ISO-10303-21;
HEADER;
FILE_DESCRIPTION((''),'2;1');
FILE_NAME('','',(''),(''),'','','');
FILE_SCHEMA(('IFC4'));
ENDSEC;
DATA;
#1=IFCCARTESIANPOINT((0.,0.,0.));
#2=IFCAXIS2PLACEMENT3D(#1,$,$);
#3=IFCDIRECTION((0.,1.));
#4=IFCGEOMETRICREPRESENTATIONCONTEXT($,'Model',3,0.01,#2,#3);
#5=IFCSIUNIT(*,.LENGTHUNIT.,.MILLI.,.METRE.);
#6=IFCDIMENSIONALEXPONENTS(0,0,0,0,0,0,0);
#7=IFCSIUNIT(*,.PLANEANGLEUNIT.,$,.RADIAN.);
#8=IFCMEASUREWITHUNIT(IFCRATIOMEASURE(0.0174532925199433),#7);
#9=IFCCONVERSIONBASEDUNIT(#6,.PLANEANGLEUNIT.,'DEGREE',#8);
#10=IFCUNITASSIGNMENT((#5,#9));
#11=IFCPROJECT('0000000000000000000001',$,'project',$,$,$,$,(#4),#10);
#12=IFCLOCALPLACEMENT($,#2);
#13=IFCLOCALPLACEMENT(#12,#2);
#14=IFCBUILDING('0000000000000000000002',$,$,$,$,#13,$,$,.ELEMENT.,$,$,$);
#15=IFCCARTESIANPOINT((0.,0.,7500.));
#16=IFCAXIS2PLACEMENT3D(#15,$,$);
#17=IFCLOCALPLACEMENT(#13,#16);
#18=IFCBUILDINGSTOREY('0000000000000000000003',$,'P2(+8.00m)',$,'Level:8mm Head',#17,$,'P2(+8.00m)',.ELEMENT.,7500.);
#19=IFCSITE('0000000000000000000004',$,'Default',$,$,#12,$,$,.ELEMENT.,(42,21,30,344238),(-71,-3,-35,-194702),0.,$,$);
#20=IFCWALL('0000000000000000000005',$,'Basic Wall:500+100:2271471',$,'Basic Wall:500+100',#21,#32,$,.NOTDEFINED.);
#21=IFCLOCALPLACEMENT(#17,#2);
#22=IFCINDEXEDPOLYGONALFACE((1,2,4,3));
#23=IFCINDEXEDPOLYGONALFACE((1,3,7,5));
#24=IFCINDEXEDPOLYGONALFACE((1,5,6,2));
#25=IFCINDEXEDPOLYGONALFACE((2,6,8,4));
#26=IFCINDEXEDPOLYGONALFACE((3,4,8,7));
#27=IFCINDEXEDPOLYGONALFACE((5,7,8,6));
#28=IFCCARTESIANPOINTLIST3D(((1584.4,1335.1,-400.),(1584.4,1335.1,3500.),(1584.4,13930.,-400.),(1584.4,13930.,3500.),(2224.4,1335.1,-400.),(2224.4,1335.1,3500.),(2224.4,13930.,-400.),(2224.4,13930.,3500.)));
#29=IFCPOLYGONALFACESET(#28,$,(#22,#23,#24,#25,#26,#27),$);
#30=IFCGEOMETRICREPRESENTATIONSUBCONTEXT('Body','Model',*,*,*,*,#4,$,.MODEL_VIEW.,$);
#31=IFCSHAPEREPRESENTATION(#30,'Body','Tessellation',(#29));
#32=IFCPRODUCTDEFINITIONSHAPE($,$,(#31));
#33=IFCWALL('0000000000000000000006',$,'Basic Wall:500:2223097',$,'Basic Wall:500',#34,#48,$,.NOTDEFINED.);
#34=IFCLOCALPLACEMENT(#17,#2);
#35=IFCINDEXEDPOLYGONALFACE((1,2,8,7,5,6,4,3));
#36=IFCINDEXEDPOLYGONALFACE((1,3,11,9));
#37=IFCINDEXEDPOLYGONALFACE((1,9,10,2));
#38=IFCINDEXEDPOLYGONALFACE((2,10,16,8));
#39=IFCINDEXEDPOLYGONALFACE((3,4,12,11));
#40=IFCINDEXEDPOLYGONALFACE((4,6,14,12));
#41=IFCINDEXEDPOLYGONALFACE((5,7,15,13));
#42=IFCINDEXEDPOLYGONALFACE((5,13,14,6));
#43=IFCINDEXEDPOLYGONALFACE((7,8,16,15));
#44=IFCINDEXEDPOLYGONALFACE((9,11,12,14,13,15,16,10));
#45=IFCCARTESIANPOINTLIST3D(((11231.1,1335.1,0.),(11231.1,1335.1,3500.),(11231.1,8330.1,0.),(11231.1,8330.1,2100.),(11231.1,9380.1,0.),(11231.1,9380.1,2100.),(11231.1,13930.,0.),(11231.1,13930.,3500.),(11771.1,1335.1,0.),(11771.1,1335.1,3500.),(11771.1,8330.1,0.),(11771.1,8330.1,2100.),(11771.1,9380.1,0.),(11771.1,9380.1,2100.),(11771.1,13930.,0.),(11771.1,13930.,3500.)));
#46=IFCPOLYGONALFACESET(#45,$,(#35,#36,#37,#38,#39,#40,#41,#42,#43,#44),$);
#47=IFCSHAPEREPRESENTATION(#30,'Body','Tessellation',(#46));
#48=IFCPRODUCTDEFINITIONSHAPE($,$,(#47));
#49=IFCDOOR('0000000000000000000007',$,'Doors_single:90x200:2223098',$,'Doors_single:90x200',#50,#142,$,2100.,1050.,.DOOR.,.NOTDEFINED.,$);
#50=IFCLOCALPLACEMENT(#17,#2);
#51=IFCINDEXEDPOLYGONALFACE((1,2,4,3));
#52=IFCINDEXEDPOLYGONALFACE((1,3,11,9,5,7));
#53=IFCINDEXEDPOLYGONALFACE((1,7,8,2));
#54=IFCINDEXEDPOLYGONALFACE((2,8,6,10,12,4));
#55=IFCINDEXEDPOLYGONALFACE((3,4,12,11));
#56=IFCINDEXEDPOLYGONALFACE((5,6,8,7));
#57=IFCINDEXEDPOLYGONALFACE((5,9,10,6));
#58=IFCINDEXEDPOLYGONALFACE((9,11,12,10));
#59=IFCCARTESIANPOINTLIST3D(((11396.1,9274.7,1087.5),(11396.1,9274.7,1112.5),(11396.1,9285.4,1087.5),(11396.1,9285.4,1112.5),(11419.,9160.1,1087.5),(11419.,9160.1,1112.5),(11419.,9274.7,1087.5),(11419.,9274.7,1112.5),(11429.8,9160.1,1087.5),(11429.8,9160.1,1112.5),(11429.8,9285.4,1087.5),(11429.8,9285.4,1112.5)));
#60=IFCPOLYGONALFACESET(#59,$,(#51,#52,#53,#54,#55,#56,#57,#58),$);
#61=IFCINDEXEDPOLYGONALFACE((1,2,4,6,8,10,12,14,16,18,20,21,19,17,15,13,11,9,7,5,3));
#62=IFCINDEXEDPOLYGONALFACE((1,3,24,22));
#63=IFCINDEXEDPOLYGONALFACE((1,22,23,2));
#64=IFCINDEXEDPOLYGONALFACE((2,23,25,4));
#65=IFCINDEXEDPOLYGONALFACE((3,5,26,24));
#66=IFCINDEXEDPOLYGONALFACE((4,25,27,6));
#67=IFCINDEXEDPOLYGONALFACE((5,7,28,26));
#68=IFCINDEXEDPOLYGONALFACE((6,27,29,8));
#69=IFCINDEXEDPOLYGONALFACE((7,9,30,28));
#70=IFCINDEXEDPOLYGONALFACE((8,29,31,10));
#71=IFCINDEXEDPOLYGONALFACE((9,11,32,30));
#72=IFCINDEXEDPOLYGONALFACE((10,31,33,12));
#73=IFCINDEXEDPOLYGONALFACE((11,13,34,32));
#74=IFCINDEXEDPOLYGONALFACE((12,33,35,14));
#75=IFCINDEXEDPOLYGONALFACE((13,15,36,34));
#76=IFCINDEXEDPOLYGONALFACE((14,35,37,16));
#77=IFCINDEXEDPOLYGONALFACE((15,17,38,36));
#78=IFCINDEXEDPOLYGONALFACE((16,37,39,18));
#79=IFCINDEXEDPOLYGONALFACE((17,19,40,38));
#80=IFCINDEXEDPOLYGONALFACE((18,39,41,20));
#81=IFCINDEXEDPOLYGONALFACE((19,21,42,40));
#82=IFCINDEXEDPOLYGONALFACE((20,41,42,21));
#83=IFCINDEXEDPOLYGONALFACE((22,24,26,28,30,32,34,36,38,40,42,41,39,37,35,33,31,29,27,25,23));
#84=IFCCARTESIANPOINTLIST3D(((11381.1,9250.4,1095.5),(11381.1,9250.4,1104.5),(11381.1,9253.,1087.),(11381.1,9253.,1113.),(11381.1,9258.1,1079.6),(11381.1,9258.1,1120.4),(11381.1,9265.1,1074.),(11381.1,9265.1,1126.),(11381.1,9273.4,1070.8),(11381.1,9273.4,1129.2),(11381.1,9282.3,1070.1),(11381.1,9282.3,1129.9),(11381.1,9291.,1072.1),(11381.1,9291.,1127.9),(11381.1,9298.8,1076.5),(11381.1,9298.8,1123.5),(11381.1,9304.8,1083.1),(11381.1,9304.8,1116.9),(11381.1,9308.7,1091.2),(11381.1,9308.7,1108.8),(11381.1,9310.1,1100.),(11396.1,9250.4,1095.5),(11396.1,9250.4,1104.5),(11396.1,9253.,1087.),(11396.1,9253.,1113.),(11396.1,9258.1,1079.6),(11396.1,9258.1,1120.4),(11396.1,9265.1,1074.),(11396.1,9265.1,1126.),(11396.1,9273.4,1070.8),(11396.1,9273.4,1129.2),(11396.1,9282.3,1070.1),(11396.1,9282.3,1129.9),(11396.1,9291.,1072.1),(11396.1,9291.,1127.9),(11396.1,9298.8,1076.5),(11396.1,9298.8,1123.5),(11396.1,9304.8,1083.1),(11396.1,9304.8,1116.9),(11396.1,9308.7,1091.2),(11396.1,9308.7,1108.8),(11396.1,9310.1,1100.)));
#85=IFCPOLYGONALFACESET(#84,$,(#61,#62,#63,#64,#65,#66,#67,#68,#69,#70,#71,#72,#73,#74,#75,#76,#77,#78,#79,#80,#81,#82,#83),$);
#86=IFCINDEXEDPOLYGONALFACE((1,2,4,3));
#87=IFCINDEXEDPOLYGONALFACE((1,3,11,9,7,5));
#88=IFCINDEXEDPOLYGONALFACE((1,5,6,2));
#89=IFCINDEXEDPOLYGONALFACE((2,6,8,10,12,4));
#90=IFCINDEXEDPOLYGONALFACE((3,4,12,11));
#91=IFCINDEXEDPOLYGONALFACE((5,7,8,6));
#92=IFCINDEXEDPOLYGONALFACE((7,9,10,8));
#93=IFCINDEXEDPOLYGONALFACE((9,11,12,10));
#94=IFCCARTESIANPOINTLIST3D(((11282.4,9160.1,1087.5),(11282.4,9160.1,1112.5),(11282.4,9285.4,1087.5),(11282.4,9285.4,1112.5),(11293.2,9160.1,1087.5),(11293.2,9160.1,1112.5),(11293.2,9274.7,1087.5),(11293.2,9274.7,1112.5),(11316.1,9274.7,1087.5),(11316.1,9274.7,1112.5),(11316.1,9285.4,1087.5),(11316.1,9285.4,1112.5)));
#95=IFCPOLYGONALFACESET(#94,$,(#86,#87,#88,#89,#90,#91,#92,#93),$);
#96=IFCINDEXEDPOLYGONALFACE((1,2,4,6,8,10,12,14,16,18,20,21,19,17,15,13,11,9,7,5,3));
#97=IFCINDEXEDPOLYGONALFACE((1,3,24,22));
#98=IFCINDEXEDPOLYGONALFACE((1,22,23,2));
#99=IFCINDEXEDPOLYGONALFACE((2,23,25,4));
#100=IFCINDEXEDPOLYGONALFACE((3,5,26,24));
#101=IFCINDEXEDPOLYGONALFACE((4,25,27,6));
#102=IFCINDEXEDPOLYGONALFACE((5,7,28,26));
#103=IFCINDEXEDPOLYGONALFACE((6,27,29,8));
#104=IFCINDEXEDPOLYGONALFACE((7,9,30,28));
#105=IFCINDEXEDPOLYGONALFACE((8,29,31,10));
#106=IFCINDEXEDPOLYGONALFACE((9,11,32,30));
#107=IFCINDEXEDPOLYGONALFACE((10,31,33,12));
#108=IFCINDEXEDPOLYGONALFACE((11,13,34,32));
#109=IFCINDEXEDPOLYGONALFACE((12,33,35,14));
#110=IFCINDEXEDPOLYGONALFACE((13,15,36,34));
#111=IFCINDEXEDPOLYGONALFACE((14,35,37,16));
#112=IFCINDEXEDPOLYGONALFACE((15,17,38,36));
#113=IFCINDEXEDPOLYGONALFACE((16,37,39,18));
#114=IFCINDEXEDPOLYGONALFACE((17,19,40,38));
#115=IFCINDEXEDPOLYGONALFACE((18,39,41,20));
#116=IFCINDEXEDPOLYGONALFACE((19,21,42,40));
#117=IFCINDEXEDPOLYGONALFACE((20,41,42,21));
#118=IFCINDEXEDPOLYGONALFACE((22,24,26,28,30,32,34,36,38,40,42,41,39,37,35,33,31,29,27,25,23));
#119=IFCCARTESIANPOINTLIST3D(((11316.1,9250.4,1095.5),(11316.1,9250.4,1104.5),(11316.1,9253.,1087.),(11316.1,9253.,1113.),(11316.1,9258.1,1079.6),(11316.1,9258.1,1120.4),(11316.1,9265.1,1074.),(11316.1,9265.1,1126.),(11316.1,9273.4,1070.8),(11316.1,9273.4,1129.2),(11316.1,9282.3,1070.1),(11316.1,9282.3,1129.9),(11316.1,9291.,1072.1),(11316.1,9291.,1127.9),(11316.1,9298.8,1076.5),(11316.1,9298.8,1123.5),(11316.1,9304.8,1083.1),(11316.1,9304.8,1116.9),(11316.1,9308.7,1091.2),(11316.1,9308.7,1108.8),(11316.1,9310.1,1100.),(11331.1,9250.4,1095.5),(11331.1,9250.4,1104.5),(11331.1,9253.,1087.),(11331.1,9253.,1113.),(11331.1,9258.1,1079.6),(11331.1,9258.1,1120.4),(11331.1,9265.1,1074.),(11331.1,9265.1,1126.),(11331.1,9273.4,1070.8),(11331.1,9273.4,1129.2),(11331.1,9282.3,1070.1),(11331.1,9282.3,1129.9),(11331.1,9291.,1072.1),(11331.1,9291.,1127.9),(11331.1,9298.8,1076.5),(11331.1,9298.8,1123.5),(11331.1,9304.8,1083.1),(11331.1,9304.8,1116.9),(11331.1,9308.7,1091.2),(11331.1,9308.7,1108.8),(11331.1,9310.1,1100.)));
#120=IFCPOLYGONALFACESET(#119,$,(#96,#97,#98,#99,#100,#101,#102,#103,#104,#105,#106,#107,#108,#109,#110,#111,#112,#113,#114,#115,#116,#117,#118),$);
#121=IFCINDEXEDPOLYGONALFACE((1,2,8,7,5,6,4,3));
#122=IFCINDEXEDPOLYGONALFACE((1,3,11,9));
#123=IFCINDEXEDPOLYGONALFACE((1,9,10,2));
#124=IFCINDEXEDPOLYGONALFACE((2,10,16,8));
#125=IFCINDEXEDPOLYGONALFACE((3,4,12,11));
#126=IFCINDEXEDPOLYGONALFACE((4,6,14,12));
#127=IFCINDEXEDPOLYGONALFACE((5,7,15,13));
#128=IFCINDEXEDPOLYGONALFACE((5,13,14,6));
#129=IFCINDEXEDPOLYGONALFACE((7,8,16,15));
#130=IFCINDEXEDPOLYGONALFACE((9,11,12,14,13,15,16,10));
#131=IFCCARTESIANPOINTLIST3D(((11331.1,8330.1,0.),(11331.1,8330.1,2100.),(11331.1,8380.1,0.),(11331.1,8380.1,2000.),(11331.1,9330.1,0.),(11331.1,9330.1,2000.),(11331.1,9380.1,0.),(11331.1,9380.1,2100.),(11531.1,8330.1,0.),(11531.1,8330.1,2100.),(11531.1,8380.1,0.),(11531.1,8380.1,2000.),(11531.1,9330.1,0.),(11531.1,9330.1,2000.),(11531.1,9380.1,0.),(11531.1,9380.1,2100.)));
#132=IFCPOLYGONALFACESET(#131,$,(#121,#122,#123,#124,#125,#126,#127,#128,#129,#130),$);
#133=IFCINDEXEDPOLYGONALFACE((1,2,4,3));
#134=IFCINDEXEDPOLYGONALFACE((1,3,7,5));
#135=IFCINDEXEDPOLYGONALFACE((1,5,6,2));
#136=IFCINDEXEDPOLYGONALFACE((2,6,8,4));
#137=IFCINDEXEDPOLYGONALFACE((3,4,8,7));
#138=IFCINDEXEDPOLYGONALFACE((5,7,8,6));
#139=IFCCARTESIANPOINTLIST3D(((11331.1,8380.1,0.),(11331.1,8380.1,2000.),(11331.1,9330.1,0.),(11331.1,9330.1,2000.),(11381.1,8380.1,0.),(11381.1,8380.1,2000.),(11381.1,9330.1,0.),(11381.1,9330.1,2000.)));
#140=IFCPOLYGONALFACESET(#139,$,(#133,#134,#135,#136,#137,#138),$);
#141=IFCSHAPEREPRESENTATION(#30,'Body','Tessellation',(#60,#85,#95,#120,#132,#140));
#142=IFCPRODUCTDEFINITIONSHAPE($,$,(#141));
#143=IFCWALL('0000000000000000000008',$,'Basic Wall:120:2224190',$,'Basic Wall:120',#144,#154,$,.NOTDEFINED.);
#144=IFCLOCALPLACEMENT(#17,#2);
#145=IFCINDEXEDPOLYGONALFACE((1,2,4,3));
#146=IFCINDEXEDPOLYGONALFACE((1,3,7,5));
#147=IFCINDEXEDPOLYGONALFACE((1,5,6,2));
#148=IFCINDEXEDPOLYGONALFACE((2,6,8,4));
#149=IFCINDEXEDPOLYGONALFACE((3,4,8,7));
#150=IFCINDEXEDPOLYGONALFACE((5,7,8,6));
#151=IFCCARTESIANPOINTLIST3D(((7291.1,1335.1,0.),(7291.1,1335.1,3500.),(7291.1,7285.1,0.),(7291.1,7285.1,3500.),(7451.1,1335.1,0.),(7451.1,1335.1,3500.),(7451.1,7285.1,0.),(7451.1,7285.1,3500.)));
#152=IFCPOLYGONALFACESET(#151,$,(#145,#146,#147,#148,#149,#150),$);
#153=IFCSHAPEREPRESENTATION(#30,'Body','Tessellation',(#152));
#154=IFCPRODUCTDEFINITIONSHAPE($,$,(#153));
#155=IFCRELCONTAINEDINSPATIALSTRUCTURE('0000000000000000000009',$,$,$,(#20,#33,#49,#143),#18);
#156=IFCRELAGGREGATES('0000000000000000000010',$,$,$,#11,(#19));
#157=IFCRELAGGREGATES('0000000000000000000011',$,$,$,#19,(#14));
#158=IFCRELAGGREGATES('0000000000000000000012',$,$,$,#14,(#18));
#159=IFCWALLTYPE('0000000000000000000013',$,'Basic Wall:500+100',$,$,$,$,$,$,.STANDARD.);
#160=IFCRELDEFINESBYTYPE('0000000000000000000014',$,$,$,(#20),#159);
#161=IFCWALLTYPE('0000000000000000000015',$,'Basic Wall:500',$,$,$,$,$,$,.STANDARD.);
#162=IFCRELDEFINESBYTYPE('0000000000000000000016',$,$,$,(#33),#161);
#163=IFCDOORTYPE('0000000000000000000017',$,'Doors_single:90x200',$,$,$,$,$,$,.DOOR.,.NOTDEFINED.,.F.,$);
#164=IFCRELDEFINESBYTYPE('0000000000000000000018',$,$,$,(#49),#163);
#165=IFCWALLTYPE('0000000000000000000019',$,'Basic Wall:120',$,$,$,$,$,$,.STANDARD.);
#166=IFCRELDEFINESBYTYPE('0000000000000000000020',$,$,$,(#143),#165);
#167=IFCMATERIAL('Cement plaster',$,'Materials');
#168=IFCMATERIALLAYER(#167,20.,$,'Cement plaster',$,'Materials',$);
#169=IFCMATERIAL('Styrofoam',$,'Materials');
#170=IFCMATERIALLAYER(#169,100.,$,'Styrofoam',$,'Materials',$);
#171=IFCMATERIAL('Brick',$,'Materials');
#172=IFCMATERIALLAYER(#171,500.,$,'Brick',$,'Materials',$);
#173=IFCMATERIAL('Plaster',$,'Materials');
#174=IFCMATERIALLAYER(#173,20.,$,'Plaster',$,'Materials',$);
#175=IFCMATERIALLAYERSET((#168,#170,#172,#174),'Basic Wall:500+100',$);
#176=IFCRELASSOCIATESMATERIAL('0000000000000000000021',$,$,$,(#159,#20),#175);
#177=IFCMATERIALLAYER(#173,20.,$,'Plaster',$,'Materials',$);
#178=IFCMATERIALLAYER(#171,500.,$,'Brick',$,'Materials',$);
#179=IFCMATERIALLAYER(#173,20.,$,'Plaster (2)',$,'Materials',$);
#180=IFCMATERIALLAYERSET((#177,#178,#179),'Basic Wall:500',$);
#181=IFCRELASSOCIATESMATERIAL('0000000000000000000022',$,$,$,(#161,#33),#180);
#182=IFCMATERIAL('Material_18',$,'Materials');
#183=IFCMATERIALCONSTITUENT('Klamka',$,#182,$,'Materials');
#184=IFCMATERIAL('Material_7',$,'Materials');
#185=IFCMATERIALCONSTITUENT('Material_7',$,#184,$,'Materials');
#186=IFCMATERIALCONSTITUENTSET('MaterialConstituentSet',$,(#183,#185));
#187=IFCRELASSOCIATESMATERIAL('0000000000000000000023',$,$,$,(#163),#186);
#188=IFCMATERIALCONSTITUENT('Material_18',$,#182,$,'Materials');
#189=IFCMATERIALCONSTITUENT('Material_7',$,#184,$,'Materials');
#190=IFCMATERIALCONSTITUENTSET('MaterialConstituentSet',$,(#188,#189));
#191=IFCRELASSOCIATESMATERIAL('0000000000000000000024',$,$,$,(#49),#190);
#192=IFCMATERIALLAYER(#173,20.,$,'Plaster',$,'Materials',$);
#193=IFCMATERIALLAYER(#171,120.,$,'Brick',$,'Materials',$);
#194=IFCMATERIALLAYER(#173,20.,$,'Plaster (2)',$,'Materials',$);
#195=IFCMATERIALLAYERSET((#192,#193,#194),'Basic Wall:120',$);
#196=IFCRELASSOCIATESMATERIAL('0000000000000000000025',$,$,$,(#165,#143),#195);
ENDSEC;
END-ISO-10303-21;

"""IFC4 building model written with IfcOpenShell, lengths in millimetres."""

from ifc_helpers import new_model, entity, si_unit, converted_unit, direction, frame, frame_2d, origin, origin_2d_with_axis, place, context, subcontext, project, spatial, polyline, rectangle, circle, outline, extrude, source, transform, mapped, material, layer, layer_set, layer_usage, constituent, constituent_set, type_object, type_shapes, element, fill, save


model = new_model("IFC4")

# Units and contexts
model_context = context("Model", 3, precision=0.01, world=origin(), true_north=direction((0.0, 1.0)))
body_context = subcontext(model_context, "Body", "Model", "MODEL_VIEW")
ifc_project = project(units=[si_unit("LENGTHUNIT", "METRE", prefix="MILLI"), converted_unit("PLANEANGLEUNIT", "DEGREE", entity("IfcRatioMeasure", 0.0174532925199433), si_unit("PLANEANGLEUNIT", "RADIAN"), dimensions=[0, 0, 0, 0, 0, 0, 0])], contexts=[model_context])

# Site, building, storey
site_placement = place(None, origin())
site = spatial("IfcSite", under=ifc_project, at=site_placement, Name="Default", CompositionType="ELEMENT", RefLatitude=(42, 21, 30, 344238), RefLongitude=(-71, -3, -35, -194702), RefElevation=0.0)
building_placement = place(site_placement, origin())
building = spatial("IfcBuilding", under=site, at=building_placement, CompositionType="ELEMENT")
storey_placement = place(building_placement, frame((0.0, 0.0, 7500.0)))
storey = spatial("IfcBuildingStorey", under=building, at=storey_placement, Name="P2(+8.00m)", ObjectType="Level:8mm Head", LongName="P2(+8.00m)", CompositionType="ELEMENT", Elevation=7500.0)

# Shared definitions
ifc_material_1 = material(Name="Styrofoam", Category="Materials")

# Wall
ifc_material_2 = material(Name="Cement plaster", Category="Materials")
ifc_layer_1 = layer(ifc_material_2, 20.0, Name="Cement plaster", Category="Materials")
ifc_layer_2 = layer(ifc_material_1, 100.0, Name="Styrofoam", Category="Materials")
ifc_material_3 = material(Name="Brick", Category="Materials")
ifc_layer_3 = layer(ifc_material_3, 500.0, Name="Brick", Category="Materials")
ifc_material_4 = material(Name="Plaster", Category="Materials")
ifc_layer_4 = layer(ifc_material_4, 20.0, Name="Plaster", Category="Materials")
ifc_layer_set_1 = layer_set([ifc_layer_1, ifc_layer_2, ifc_layer_3, ifc_layer_4], Name="Basic Wall:500+100")
ifc_layer_usage_1 = layer_usage(ifc_layer_set_1, "AXIS2", "NEGATIVE", 320.0)
wall_type_1 = type_object("IfcWallType", Name="Basic Wall:500+100", PredefinedType="STANDARD", material=ifc_layer_set_1)
wall_1_placement = place(storey_placement, frame((1904.4, 1335.1, -400.0), z_axis=(0.0, 0.0, 1.0), x_axis=(0.0, 1.0, 0.0)))
element("IfcWall", 1, at=wall_1_placement, inside=storey, type_object=wall_type_1, material=ifc_layer_usage_1, Name="Basic Wall:500+100:2271471", ObjectType="Basic Wall:500+100", PredefinedType="NOTDEFINED", context=body_context, shape_type="SweptSolid", body=[
    extrude(rectangle(XDim=12594.9, YDim=640.0, at=frame_2d((6297.5, 0.0), x_axis=(-1.0, 0.0))), origin(), (0.0, 0.0, 1.0), 3900.0),
])

# Shared definitions
ifc_layer_5 = layer(ifc_material_4, 20.0, Name="Plaster", Category="Materials")
ifc_layer_6 = layer(ifc_material_3, 500.0, Name="Brick", Category="Materials")
ifc_layer_7 = layer(ifc_material_4, 20.0, Name="Plaster (2)", Category="Materials")
ifc_layer_set_2 = layer_set([ifc_layer_5, ifc_layer_6, ifc_layer_7], Name="Basic Wall:500")
wall_type_2 = type_object("IfcWallType", Name="Basic Wall:500", PredefinedType="STANDARD", material=ifc_layer_set_2)

# Wall, opening, door
ifc_layer_usage_2 = layer_usage(ifc_layer_set_2, "AXIS2", "NEGATIVE", 270.0)
wall_2_placement = place(storey_placement, frame((11501.1, 1335.1, 0.0), z_axis=(0.0, 0.0, 1.0), x_axis=(0.0, 1.0, 0.0)))
wall_2 = element("IfcWall", 2, at=wall_2_placement, inside=storey, type_object=wall_type_2, material=ifc_layer_usage_2, Name="Basic Wall:500:2223097", ObjectType="Basic Wall:500", PredefinedType="NOTDEFINED", context=body_context, shape_type="SweptSolid", body=[
    extrude(rectangle(XDim=12594.9, YDim=540.0, at=frame_2d((6297.5, 0.0), x_axis=(-1.0, 0.0))), origin(), (0.0, 0.0, 1.0), 3500.0),
])
opening_1_placement = place(wall_2_placement, frame((6995.0, -270.0, 0.0)))
opening_1 = element("IfcOpeningElement", 3, at=opening_1_placement, cuts=wall_2, PredefinedType="OPENING", context=body_context, shape_type="SweptSolid", body=[
    extrude(rectangle(XDim=2100.0, YDim=1050.0, at=frame_2d((1050.0, 525.0), x_axis=(1.0, 0.0))), frame((0.0, 0.0, 0.0), z_axis=(0.0, 1.0, 0.0), x_axis=(0.0, 0.0, 1.0)), (0.0, 0.0, 1.0), 540.0),
])
ifc_material_5 = material(Name="Material_18", Category="Materials")
ifc_constituent_1 = constituent(ifc_material_5, Name="Material_18", Category="Materials")
ifc_material_6 = material(Name="Material_7", Category="Materials")
ifc_constituent_2 = constituent(ifc_material_6, Name="Material_7", Category="Materials")
ifc_constituent_set_1 = constituent_set(constituents=[ifc_constituent_1, ifc_constituent_2], Name="MaterialConstituentSet")
ifc_constituent_3 = constituent(ifc_material_5, Name="Klamka", Category="Materials")
ifc_constituent_4 = constituent(ifc_material_6, Name="Material_7", Category="Materials")
ifc_constituent_set_2 = constituent_set(constituents=[ifc_constituent_3, ifc_constituent_4], Name="MaterialConstituentSet")
door_type_1 = type_object("IfcDoorType", Name="Doors_single:90x200", OperationType="NOTDEFINED", ParameterTakesPrecedence=False, PredefinedType="DOOR", material=ifc_constituent_set_2)
shared_shape_1 = source(origin(), body_context, "Body", "SweptSolid", [
    extrude(outline(polyline([(-45.4, -18.9), (-34.6, -18.9), (-34.6, 4.0), (80.0, 4.0), (80.0, 14.8), (-45.4, 14.8), (-45.4, -18.9)])), frame((910.0, 356.1, 1087.5), z_axis=(0.0, 0.0, 1.0), x_axis=(-1.0, 0.0, 0.0)), (0.0, 0.0, 1.0), 25.0),
    extrude(circle(Radius=30.0, at=origin_2d_with_axis()), frame((950.0, 375.0, 1100.0), z_axis=(0.0, 1.0, 0.0), x_axis=(1.0, 0.0, 0.0)), (0.0, 0.0, 1.0), 15.0),
    extrude(outline(polyline([(-18.9, -45.4), (14.8, -45.4), (14.8, 80.0), (4.0, 80.0), (4.0, -34.6), (-18.9, -34.6), (-18.9, -45.4)])), frame((910.0, 473.9, 1087.5), z_axis=(0.0, 0.0, 1.0), x_axis=(0.0, 1.0, 0.0)), (0.0, 0.0, 1.0), 25.0),
    extrude(circle(Radius=30.0, at=origin_2d_with_axis()), frame((950.0, 440.0, 1100.0), z_axis=(0.0, 1.0, 0.0), x_axis=(1.0, 0.0, 0.0)), (0.0, 0.0, 1.0), 15.0),
    extrude(outline(polyline([(-525.0, -1025.0), (-475.0, -1025.0), (-475.0, 975.0), (475.0, 975.0), (475.0, -1025.0), (525.0, -1025.0), (525.0, 1075.0), (-525.0, 1075.0), (-525.0, -1025.0)])), frame((525.0, 240.0, 1025.0), z_axis=(0.0, 1.0, 0.0), x_axis=(-1.0, 0.0, 0.0)), (0.0, 0.0, 1.0), 200.0),
    extrude(rectangle(XDim=950.0, YDim=50.0, at=frame_2d((0.0, 0.0), x_axis=(1.0, 0.0))), frame((525.0, 415.0, 0.0), z_axis=(0.0, 0.0, 1.0), x_axis=(-1.0, 0.0, 0.0)), (0.0, 0.0, 1.0), 2000.0),
])
type_shapes(door_type_1, [shared_shape_1])
door_1_placement = place(opening_1_placement, origin())
door_1 = element("IfcDoor", 4, at=door_1_placement, inside=storey, type_object=door_type_1, material=ifc_constituent_set_1, Name="Doors_single:90x200:2223098", ObjectType="Doors_single:90x200", OperationType="NOTDEFINED", OverallHeight=2100.0, OverallWidth=1050.0, PredefinedType="DOOR", context=body_context, shape_type="MappedRepresentation", body=[
    mapped(shared_shape_1, transform((0.0, 0.0, 0.0), scale=1.0)),
])
fill(opening_1, door_1)

# Wall
ifc_layer_8 = layer(ifc_material_4, 20.0, Name="Plaster", Category="Materials")
ifc_layer_9 = layer(ifc_material_3, 120.0, Name="Brick", Category="Materials")
ifc_layer_10 = layer(ifc_material_4, 20.0, Name="Plaster (2)", Category="Materials")
ifc_layer_set_3 = layer_set([ifc_layer_8, ifc_layer_9, ifc_layer_10], Name="Basic Wall:120")
ifc_layer_usage_3 = layer_usage(ifc_layer_set_3, "AXIS2", "POSITIVE", -80.0)
wall_type_3 = type_object("IfcWallType", Name="Basic Wall:120", PredefinedType="STANDARD", material=ifc_layer_set_3)
wall_3_placement = place(storey_placement, frame((7371.1, 7285.1, 0.0), z_axis=(0.0, 0.0, 1.0), x_axis=(0.0, -1.0, 0.0)))
element("IfcWall", 5, at=wall_3_placement, inside=storey, type_object=wall_type_3, material=ifc_layer_usage_3, Name="Basic Wall:120:2224190", ObjectType="Basic Wall:120", PredefinedType="NOTDEFINED", context=body_context, shape_type="SweptSolid", body=[
    extrude(rectangle(XDim=5950.0, YDim=160.0, at=frame_2d((2975.0, 0.0), x_axis=(-1.0, 0.0))), origin(), (0.0, 0.0, 1.0), 3500.0),
])

save(model, "model.ifc")
